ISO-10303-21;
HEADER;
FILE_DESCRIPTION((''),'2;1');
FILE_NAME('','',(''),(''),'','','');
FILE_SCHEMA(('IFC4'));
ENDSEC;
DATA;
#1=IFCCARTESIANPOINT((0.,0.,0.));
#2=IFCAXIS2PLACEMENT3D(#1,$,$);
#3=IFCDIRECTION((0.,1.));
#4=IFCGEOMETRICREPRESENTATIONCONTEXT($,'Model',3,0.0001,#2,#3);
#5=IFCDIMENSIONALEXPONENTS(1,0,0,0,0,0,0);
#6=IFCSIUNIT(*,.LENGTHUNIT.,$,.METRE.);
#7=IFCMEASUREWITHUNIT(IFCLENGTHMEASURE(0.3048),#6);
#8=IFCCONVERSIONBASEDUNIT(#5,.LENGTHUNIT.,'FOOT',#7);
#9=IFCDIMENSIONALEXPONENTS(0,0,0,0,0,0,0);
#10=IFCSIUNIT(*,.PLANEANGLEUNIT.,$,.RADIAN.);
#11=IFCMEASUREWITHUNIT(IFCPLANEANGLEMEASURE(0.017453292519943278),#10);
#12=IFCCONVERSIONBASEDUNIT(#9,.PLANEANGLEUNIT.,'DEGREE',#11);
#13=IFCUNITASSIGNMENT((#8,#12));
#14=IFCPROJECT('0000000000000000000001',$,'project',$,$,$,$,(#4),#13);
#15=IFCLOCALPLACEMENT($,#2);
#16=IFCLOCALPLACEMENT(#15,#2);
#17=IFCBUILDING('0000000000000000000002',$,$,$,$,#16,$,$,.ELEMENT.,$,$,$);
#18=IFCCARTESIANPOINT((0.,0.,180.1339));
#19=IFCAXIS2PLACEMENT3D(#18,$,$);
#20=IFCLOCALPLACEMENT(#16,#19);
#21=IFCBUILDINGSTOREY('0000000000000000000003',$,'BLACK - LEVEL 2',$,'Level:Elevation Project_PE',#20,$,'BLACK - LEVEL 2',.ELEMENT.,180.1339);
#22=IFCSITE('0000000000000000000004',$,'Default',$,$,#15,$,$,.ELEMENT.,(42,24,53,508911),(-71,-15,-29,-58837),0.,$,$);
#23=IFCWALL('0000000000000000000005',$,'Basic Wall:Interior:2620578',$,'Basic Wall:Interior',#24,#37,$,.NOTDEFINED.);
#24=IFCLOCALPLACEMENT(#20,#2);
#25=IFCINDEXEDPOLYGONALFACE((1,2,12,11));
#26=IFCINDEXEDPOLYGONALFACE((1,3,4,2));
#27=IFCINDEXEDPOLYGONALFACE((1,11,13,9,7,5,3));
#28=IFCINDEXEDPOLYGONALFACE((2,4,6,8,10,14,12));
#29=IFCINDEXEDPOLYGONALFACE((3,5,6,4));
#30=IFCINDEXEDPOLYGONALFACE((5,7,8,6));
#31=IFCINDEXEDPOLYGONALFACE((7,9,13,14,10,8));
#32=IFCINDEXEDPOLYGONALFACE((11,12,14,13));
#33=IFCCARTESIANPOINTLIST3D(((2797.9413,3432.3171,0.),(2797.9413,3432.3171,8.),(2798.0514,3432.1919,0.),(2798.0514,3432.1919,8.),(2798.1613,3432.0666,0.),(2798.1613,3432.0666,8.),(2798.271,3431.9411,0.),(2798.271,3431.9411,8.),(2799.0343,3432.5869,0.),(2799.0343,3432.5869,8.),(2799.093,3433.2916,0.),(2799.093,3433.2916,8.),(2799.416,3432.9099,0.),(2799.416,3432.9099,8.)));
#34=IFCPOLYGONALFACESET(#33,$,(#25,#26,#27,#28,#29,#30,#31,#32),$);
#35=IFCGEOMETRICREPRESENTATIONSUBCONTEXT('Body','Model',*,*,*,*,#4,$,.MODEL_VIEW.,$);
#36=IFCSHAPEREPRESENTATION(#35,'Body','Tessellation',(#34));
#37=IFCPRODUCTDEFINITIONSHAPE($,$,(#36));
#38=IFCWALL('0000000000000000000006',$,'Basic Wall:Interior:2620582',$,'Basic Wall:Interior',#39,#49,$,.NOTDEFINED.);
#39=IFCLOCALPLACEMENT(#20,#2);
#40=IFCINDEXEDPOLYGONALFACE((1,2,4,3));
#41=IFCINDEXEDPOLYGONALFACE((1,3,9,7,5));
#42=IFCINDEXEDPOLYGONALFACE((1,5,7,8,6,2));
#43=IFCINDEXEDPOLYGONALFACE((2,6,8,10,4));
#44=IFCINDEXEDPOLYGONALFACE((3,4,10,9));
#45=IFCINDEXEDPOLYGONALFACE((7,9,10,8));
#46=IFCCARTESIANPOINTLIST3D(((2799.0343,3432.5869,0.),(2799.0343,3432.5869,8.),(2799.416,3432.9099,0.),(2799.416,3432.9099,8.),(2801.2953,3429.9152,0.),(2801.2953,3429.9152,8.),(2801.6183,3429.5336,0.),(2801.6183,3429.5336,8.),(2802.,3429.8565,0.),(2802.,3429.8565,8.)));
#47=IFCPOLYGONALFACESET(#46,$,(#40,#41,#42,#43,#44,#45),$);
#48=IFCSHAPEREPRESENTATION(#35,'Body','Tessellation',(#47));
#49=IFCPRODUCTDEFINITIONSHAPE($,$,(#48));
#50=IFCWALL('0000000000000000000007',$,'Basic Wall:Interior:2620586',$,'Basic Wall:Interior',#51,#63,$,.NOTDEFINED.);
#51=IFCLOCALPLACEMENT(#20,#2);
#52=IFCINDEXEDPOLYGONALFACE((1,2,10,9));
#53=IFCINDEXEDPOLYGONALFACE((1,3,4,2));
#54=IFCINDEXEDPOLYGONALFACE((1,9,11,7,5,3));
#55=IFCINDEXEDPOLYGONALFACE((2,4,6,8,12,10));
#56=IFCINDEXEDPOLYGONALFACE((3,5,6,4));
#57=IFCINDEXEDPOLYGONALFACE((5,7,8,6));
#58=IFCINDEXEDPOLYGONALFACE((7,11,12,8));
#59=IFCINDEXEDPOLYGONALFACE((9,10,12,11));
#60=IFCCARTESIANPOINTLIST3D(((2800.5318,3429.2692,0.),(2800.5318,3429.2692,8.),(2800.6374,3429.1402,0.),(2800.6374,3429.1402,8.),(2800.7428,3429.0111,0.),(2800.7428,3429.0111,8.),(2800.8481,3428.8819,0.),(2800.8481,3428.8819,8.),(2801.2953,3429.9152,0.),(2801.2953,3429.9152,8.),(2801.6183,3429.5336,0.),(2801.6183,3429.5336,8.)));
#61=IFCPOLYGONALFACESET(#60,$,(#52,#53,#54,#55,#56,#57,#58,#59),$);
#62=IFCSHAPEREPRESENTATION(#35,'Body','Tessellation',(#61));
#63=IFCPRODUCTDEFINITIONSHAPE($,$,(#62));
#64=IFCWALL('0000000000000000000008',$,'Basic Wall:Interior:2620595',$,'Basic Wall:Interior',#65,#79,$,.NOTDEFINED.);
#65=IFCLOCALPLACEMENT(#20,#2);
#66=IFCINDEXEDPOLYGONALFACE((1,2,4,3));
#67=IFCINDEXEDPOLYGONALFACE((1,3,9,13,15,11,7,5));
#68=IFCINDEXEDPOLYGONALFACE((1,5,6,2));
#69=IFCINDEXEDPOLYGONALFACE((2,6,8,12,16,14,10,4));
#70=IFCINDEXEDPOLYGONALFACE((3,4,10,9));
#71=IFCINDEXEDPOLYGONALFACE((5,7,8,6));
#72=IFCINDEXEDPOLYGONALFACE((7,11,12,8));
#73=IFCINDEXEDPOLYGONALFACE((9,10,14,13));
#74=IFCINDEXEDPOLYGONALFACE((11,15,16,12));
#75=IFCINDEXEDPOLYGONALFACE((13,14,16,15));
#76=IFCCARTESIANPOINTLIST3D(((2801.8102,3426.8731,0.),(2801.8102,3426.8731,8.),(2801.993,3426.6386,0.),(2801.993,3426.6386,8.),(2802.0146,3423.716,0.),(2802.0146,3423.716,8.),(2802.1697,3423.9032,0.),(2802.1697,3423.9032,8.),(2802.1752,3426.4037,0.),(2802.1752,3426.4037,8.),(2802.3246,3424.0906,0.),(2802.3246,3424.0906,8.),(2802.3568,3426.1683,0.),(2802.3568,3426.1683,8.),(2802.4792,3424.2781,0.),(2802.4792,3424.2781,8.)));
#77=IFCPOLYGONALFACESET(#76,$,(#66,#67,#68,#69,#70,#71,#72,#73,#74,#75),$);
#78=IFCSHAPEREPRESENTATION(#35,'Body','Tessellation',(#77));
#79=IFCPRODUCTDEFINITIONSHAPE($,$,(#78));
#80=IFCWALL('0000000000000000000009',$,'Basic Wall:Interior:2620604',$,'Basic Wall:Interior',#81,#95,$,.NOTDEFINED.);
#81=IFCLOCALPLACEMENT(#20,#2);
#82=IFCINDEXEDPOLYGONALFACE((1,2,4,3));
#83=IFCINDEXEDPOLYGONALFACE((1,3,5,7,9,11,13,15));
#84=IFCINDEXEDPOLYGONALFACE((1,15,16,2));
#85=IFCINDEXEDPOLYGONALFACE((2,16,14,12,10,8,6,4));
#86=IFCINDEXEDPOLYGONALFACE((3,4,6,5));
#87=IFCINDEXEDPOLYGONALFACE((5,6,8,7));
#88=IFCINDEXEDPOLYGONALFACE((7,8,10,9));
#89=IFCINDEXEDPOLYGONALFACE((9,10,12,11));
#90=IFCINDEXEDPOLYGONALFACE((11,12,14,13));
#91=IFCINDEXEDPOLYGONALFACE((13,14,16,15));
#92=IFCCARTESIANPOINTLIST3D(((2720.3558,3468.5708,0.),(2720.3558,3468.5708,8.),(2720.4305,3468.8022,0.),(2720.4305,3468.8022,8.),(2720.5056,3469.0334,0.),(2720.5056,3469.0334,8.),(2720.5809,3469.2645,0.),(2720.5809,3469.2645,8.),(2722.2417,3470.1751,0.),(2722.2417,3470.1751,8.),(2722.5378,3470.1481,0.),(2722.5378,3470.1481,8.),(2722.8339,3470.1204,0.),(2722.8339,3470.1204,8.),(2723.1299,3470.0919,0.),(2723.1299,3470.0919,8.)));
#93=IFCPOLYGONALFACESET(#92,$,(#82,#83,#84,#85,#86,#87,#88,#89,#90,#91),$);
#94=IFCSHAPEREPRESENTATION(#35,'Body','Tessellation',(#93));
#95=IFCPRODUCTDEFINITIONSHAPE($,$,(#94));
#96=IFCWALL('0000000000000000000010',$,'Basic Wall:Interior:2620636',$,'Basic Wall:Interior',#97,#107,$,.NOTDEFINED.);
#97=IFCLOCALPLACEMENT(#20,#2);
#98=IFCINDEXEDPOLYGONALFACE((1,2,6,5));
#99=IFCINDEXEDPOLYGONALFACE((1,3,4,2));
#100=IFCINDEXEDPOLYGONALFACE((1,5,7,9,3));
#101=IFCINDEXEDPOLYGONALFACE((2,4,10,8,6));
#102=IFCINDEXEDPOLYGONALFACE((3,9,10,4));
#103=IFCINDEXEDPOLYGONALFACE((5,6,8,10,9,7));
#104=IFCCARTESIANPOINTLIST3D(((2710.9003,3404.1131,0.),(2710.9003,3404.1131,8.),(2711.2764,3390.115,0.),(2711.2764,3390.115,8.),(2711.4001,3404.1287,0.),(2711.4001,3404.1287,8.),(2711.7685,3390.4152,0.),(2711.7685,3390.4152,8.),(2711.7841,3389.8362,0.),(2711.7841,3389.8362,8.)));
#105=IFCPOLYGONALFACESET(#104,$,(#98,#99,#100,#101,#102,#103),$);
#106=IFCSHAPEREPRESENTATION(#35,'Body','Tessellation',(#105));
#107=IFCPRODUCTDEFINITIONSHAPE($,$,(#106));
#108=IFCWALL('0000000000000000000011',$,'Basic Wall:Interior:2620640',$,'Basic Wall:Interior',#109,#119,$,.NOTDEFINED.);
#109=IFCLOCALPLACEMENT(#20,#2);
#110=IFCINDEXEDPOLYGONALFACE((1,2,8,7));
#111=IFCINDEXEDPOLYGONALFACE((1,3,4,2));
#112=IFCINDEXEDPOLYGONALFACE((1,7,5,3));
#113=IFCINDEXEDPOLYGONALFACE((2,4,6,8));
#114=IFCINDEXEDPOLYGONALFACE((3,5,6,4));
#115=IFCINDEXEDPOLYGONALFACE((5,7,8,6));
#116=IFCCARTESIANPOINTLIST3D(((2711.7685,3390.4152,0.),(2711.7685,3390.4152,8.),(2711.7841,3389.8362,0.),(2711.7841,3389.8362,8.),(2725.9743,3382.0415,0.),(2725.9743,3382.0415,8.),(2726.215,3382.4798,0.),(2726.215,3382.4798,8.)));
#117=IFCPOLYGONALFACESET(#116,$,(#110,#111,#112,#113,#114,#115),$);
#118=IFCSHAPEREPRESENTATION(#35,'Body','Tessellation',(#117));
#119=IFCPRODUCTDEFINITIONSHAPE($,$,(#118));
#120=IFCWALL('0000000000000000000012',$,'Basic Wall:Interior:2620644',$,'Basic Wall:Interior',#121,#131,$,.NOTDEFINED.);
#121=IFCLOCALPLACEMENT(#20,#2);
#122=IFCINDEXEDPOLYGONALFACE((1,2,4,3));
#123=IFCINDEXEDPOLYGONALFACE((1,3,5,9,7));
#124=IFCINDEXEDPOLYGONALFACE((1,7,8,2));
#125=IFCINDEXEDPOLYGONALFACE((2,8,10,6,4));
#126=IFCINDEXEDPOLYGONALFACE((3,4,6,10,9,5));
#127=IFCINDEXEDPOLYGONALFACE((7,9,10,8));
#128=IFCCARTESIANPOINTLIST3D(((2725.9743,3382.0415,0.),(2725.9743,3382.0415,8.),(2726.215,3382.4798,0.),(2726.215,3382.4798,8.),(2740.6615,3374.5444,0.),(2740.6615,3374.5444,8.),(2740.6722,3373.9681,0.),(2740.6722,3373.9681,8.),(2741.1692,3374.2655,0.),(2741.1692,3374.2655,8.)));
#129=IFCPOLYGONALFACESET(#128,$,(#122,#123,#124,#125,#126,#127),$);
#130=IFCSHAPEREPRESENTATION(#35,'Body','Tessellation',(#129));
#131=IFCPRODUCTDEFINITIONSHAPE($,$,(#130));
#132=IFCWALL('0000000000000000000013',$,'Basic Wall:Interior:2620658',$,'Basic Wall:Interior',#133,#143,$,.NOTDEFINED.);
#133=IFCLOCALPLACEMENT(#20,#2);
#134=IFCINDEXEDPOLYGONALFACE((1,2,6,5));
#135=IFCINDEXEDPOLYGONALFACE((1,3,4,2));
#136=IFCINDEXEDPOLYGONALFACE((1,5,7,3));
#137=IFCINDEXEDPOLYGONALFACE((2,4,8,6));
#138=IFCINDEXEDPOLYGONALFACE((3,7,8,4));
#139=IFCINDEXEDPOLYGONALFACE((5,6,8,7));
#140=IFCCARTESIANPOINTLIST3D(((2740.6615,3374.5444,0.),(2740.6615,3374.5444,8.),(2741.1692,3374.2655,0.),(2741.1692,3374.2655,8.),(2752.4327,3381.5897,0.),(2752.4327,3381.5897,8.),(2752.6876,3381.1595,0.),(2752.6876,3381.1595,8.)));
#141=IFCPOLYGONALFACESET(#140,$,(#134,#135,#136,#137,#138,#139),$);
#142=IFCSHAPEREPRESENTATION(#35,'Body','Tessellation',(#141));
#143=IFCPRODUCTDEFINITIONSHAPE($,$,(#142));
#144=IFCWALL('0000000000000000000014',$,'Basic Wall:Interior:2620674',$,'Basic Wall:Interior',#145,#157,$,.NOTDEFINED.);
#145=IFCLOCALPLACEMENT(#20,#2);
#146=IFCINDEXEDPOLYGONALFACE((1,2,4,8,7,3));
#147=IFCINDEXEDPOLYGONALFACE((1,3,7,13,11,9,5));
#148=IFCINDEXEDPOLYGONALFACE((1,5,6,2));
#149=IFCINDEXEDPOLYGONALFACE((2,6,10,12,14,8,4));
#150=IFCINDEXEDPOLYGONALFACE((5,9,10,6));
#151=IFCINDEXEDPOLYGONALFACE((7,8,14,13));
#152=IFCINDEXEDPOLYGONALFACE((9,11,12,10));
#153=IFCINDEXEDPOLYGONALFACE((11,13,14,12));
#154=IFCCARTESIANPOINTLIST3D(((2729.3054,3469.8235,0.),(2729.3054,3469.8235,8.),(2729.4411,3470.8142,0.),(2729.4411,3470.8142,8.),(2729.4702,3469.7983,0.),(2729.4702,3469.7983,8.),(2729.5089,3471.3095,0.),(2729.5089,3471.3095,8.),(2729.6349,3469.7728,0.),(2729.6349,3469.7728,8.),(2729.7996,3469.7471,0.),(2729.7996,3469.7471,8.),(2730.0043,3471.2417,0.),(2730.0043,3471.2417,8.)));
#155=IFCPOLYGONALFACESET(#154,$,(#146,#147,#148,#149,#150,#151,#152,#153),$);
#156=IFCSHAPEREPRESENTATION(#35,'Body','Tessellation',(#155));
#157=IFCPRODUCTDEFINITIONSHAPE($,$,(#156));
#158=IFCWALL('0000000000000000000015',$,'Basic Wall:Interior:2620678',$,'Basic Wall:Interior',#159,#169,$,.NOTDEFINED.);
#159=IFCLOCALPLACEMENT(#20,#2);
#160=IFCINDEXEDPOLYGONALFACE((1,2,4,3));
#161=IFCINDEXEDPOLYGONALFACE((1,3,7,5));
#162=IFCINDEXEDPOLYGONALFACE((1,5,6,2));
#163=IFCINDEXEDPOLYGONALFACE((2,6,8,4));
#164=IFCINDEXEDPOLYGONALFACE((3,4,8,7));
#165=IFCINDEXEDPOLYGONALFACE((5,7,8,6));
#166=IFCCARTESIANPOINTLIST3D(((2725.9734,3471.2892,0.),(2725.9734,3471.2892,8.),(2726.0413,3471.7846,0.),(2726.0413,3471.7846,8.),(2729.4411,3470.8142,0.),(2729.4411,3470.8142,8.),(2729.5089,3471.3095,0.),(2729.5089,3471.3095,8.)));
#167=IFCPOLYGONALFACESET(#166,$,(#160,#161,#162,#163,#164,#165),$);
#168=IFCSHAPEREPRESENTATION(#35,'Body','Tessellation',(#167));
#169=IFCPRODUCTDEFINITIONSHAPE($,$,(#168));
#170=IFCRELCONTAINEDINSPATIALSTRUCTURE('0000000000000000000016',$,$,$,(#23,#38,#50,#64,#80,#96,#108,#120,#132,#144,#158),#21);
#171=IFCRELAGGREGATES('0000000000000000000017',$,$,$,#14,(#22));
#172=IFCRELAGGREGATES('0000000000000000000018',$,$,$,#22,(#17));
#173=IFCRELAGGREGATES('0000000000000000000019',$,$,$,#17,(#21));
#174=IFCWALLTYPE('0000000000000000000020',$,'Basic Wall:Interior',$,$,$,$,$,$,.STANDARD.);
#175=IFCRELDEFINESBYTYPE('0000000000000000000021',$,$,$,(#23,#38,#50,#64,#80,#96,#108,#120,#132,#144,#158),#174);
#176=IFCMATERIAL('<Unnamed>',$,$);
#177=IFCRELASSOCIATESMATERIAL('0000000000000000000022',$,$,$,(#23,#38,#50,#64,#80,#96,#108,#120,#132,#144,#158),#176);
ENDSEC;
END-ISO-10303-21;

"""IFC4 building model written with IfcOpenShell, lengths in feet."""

from ifc_helpers import new_model, entity, si_unit, converted_unit, direction, frame, origin, place, context, subcontext, project, spatial, line, arc, indexed_curve, outline, extrude, material, type_object, element, save


model = new_model("IFC4")

# Units and contexts
model_context = context("Model", 3, precision=0.0001, world=origin(), true_north=direction((0.0, 1.0)))
body_context = subcontext(model_context, "Body", "Model", "MODEL_VIEW")
ifc_project = project(units=[converted_unit("LENGTHUNIT", "FOOT", entity("IfcLengthMeasure", 0.3048), si_unit("LENGTHUNIT", "METRE"), dimensions=[1, 0, 0, 0, 0, 0, 0]), converted_unit("PLANEANGLEUNIT", "DEGREE", entity("IfcPlaneAngleMeasure", 0.017453292519943278), si_unit("PLANEANGLEUNIT", "RADIAN"), dimensions=[0, 0, 0, 0, 0, 0, 0])], contexts=[model_context])

# Site, building, storey
site_placement = place(None, origin())
site = spatial("IfcSite", under=ifc_project, at=site_placement, Name="Default", CompositionType="ELEMENT", RefLatitude=(42, 24, 53, 508911), RefLongitude=(-71, -15, -29, -58837), RefElevation=0.0)
building_placement = place(site_placement, origin())
building = spatial("IfcBuilding", under=site, at=building_placement, CompositionType="ELEMENT")
storey_placement = place(building_placement, frame((0.0, 0.0, 180.1339)))
storey = spatial("IfcBuildingStorey", under=building, at=storey_placement, Name="BLACK - LEVEL 2", ObjectType="Level:Elevation Project_PE", LongName="BLACK - LEVEL 2", CompositionType="ELEMENT", Elevation=180.1339)

# Walls
ifc_material = material(Name="<Unnamed>")
wall_type = type_object("IfcWallType", Name="Basic Wall:Interior", PredefinedType="STANDARD")
wall_1_placement = place(storey_placement, frame((2798.1028, 3432.1263, 0.0), z_axis=(0.0, 0.0, 1.0), x_axis=(0.76339, 0.645938, 0.0)))
element("IfcWall", 1, at=wall_1_placement, inside=storey, type_object=wall_type, material=ifc_material, Name="Basic Wall:Interior:2620578", ObjectType="Basic Wall:Interior", PredefinedType="NOTDEFINED", context=body_context, shape_type="SweptSolid", body=[
    extrude(outline(indexed_curve([(1.5086, -0.25), (1.5086, 0.25), (0.0, 0.25), (0.0046, 0.0), (0.0087, -0.25), (1.0086, -0.25)], segments=[line(1, 2, 3), arc(3, 4, 5), line(5, 6, 1)], self_intersect=False)), origin(), (0.0, 0.0, 1.0), 8.0),
])
wall_2_placement = place(storey_placement, frame((2799.2251, 3432.7484, 0.0), z_axis=(0.0, 0.0, 1.0), x_axis=(0.645999, -0.763338, 0.0)))
element("IfcWall", 2, at=wall_2_placement, inside=storey, type_object=wall_type, material=ifc_material, Name="Basic Wall:Interior:2620582", ObjectType="Basic Wall:Interior", PredefinedType="NOTDEFINED", context=body_context, shape_type="SweptSolid", body=[
    extrude(outline(indexed_curve([(4.0, -0.25), (4.0, 0.25), (0.0, 0.25), (0.0, -0.25), (3.5, -0.25), (4.0, -0.25)], self_intersect=False)), origin(), (0.0, 0.0, 1.0), 8.0),
])
wall_3_placement = place(storey_placement, frame((2801.4568, 3429.7244, 0.0), z_axis=(0.0, 0.0, 1.0), x_axis=(-0.76339, -0.645938, 0.0)))
element("IfcWall", 3, at=wall_3_placement, inside=storey, type_object=wall_type, material=ifc_material, Name="Basic Wall:Interior:2620586", ObjectType="Basic Wall:Interior", PredefinedType="NOTDEFINED", context=body_context, shape_type="SweptSolid", body=[
    extrude(outline(indexed_curve([(1.0002, -0.25), (1.0043, 0.0), (1.0089, 0.25), (0.0, 0.25), (0.0, -0.25)], segments=[arc(1, 2, 3), line(3, 4, 5, 1)], self_intersect=False)), origin(), (0.0, 0.0, 1.0), 8.0),
])
wall_4_placement = place(storey_placement, frame((2802.0596, 3426.8893, 0.0), z_axis=(0.0, 0.0, 1.0), x_axis=(0.064605, -0.997911, 0.0)))
element("IfcWall", 4, at=wall_4_placement, inside=storey, type_object=wall_type, material=ifc_material, Name="Basic Wall:Interior:2620595", ObjectType="Basic Wall:Interior", PredefinedType="NOTDEFINED", context=body_context, shape_type="SweptSolid", body=[
    extrude(outline(indexed_curve([(3.1637, -0.25), (2.8985, 0.0003), (2.6328, 0.25), (0.7387, 0.25), (0.3689, 0.0007), (0.0, -0.25)], segments=[arc(1, 2, 3), line(3, 4), arc(4, 5, 6), line(6, 1)], self_intersect=False)), origin(), (0.0, 0.0, 1.0), 8.0),
])
wall_5_placement = place(storey_placement, frame((2720.2356, 3468.79, 0.0), z_axis=(0.0, 0.0, 1.0), x_axis=(0.876842, 0.480778, 0.0)))
element("IfcWall", 5, at=wall_5_placement, inside=storey, type_object=wall_type, material=ifc_material, Name="Basic Wall:Interior:2620604", ObjectType="Basic Wall:Interior", PredefinedType="NOTDEFINED", context=body_context, shape_type="SweptSolid", body=[
    extrude(outline(indexed_curve([(3.1637, -0.25), (2.7948, 0.0007), (2.425, 0.25), (0.5309, 0.25), (0.2652, 0.0003), (0.0, -0.25)], segments=[arc(1, 2, 3), line(3, 4), arc(4, 5, 6), line(6, 1)], self_intersect=False)), origin(), (0.0, 0.0, 1.0), 8.0),
])
wall_6_placement = place(storey_placement, frame((2711.5341, 3389.8295, 0.0), z_axis=(0.0, 0.0, 1.0), x_axis=(-0.026857, 0.999639, 0.0)))
element("IfcWall", 6, at=wall_6_placement, inside=storey, type_object=wall_type, material=ifc_material, Name="Basic Wall:Interior:2620636", ObjectType="Basic Wall:Interior", PredefinedType="NOTDEFINED", context=body_context, shape_type="SweptSolid", body=[
    extrude(outline(indexed_curve([(14.2977, -0.25), (14.2955, 0.25), (0.2924, 0.25), (0.0, -0.25), (0.5792, -0.25), (14.2977, -0.25)], self_intersect=False)), origin(), (0.0, 0.0, 1.0), 8.0),
])
wall_7_placement = place(storey_placement, frame((2726.0947, 3382.2607, 0.0), z_axis=(0.0, 0.0, 1.0), x_axis=(-0.876477, 0.481445, 0.0)))
element("IfcWall", 7, at=wall_7_placement, inside=storey, type_object=wall_type, material=ifc_material, Name="Basic Wall:Interior:2620640", ObjectType="Basic Wall:Interior", PredefinedType="NOTDEFINED", context=body_context, shape_type="SweptSolid", body=[
    extrude(outline(indexed_curve([(16.4825, -0.25), (16.1901, 0.25), (0.0, 0.25), (0.0, -0.25), (16.4825, -0.25)], self_intersect=False)), origin(), (0.0, 0.0, 1.0), 8.0),
])
wall_8_placement = place(storey_placement, frame((2741.0488, 3374.0464, 0.0), z_axis=(0.0, 0.0, 1.0), x_axis=(-0.876477, 0.481445, 0.0)))
element("IfcWall", 8, at=wall_8_placement, inside=storey, type_object=wall_type, material=ifc_material, Name="Basic Wall:Interior:2620644", ObjectType="Basic Wall:Interior", PredefinedType="NOTDEFINED", context=body_context, shape_type="SweptSolid", body=[
    extrude(outline(indexed_curve([(17.0617, -0.25), (17.0617, 0.25), (0.2924, 0.25), (0.0, -0.25), (0.5792, -0.25), (17.0617, -0.25)], self_intersect=False)), origin(), (0.0, 0.0, 1.0), 8.0),
])
wall_9_placement = place(storey_placement, frame((2752.5611, 3381.3752, 0.0), z_axis=(0.0, 0.0, 1.0), x_axis=(-0.858052, -0.513563, 0.0)))
element("IfcWall", 9, at=wall_9_placement, inside=storey, type_object=wall_type, material=ifc_material, Name="Basic Wall:Interior:2620658", ObjectType="Basic Wall:Interior", PredefinedType="NOTDEFINED", context=body_context, shape_type="SweptSolid", body=[
    extrude(outline(indexed_curve([(13.7185, -0.25), (13.4261, 0.25), (0.0022, 0.25), (0.0, -0.25), (13.7185, -0.25)], self_intersect=False)), origin(), (0.0, 0.0, 1.0), 8.0),
])
wall_10_placement = place(storey_placement, frame((2729.7566, 3471.2756, 0.0), z_axis=(0.0, 0.0, 1.0), x_axis=(-0.13564, -0.990758, 0.0)))
element("IfcWall", 10, at=wall_10_placement, inside=storey, type_object=wall_type, material=ifc_material, Name="Basic Wall:Interior:2620674", ObjectType="Basic Wall:Interior", PredefinedType="NOTDEFINED", context=body_context, shape_type="SweptSolid", body=[
    extrude(outline(indexed_curve([(1.4999, -0.25), (1.504, 0.0), (1.5086, 0.25), (0.0, 0.25), (0.0, -0.25), (0.5, -0.25)], segments=[arc(1, 2, 3), line(3, 4, 5, 6, 1)], self_intersect=False)), origin(), (0.0, 0.0, 1.0), 8.0),
])
wall_11_placement = place(storey_placement, frame((2726.0073, 3471.5369, 0.0), z_axis=(0.0, 0.0, 1.0), x_axis=(0.990747, -0.135719, 0.0)))
element("IfcWall", 11, at=wall_11_placement, inside=storey, type_object=wall_type, material=ifc_material, Name="Basic Wall:Interior:2620678", ObjectType="Basic Wall:Interior", PredefinedType="NOTDEFINED", context=body_context, shape_type="SweptSolid", body=[
    extrude(outline(indexed_curve([(3.5, -0.25), (3.5, 0.25), (0.0, 0.25), (0.0, -0.25), (3.5, -0.25)], self_intersect=False)), origin(), (0.0, 0.0, 1.0), 8.0),
])

save(model, "model.ifc")
